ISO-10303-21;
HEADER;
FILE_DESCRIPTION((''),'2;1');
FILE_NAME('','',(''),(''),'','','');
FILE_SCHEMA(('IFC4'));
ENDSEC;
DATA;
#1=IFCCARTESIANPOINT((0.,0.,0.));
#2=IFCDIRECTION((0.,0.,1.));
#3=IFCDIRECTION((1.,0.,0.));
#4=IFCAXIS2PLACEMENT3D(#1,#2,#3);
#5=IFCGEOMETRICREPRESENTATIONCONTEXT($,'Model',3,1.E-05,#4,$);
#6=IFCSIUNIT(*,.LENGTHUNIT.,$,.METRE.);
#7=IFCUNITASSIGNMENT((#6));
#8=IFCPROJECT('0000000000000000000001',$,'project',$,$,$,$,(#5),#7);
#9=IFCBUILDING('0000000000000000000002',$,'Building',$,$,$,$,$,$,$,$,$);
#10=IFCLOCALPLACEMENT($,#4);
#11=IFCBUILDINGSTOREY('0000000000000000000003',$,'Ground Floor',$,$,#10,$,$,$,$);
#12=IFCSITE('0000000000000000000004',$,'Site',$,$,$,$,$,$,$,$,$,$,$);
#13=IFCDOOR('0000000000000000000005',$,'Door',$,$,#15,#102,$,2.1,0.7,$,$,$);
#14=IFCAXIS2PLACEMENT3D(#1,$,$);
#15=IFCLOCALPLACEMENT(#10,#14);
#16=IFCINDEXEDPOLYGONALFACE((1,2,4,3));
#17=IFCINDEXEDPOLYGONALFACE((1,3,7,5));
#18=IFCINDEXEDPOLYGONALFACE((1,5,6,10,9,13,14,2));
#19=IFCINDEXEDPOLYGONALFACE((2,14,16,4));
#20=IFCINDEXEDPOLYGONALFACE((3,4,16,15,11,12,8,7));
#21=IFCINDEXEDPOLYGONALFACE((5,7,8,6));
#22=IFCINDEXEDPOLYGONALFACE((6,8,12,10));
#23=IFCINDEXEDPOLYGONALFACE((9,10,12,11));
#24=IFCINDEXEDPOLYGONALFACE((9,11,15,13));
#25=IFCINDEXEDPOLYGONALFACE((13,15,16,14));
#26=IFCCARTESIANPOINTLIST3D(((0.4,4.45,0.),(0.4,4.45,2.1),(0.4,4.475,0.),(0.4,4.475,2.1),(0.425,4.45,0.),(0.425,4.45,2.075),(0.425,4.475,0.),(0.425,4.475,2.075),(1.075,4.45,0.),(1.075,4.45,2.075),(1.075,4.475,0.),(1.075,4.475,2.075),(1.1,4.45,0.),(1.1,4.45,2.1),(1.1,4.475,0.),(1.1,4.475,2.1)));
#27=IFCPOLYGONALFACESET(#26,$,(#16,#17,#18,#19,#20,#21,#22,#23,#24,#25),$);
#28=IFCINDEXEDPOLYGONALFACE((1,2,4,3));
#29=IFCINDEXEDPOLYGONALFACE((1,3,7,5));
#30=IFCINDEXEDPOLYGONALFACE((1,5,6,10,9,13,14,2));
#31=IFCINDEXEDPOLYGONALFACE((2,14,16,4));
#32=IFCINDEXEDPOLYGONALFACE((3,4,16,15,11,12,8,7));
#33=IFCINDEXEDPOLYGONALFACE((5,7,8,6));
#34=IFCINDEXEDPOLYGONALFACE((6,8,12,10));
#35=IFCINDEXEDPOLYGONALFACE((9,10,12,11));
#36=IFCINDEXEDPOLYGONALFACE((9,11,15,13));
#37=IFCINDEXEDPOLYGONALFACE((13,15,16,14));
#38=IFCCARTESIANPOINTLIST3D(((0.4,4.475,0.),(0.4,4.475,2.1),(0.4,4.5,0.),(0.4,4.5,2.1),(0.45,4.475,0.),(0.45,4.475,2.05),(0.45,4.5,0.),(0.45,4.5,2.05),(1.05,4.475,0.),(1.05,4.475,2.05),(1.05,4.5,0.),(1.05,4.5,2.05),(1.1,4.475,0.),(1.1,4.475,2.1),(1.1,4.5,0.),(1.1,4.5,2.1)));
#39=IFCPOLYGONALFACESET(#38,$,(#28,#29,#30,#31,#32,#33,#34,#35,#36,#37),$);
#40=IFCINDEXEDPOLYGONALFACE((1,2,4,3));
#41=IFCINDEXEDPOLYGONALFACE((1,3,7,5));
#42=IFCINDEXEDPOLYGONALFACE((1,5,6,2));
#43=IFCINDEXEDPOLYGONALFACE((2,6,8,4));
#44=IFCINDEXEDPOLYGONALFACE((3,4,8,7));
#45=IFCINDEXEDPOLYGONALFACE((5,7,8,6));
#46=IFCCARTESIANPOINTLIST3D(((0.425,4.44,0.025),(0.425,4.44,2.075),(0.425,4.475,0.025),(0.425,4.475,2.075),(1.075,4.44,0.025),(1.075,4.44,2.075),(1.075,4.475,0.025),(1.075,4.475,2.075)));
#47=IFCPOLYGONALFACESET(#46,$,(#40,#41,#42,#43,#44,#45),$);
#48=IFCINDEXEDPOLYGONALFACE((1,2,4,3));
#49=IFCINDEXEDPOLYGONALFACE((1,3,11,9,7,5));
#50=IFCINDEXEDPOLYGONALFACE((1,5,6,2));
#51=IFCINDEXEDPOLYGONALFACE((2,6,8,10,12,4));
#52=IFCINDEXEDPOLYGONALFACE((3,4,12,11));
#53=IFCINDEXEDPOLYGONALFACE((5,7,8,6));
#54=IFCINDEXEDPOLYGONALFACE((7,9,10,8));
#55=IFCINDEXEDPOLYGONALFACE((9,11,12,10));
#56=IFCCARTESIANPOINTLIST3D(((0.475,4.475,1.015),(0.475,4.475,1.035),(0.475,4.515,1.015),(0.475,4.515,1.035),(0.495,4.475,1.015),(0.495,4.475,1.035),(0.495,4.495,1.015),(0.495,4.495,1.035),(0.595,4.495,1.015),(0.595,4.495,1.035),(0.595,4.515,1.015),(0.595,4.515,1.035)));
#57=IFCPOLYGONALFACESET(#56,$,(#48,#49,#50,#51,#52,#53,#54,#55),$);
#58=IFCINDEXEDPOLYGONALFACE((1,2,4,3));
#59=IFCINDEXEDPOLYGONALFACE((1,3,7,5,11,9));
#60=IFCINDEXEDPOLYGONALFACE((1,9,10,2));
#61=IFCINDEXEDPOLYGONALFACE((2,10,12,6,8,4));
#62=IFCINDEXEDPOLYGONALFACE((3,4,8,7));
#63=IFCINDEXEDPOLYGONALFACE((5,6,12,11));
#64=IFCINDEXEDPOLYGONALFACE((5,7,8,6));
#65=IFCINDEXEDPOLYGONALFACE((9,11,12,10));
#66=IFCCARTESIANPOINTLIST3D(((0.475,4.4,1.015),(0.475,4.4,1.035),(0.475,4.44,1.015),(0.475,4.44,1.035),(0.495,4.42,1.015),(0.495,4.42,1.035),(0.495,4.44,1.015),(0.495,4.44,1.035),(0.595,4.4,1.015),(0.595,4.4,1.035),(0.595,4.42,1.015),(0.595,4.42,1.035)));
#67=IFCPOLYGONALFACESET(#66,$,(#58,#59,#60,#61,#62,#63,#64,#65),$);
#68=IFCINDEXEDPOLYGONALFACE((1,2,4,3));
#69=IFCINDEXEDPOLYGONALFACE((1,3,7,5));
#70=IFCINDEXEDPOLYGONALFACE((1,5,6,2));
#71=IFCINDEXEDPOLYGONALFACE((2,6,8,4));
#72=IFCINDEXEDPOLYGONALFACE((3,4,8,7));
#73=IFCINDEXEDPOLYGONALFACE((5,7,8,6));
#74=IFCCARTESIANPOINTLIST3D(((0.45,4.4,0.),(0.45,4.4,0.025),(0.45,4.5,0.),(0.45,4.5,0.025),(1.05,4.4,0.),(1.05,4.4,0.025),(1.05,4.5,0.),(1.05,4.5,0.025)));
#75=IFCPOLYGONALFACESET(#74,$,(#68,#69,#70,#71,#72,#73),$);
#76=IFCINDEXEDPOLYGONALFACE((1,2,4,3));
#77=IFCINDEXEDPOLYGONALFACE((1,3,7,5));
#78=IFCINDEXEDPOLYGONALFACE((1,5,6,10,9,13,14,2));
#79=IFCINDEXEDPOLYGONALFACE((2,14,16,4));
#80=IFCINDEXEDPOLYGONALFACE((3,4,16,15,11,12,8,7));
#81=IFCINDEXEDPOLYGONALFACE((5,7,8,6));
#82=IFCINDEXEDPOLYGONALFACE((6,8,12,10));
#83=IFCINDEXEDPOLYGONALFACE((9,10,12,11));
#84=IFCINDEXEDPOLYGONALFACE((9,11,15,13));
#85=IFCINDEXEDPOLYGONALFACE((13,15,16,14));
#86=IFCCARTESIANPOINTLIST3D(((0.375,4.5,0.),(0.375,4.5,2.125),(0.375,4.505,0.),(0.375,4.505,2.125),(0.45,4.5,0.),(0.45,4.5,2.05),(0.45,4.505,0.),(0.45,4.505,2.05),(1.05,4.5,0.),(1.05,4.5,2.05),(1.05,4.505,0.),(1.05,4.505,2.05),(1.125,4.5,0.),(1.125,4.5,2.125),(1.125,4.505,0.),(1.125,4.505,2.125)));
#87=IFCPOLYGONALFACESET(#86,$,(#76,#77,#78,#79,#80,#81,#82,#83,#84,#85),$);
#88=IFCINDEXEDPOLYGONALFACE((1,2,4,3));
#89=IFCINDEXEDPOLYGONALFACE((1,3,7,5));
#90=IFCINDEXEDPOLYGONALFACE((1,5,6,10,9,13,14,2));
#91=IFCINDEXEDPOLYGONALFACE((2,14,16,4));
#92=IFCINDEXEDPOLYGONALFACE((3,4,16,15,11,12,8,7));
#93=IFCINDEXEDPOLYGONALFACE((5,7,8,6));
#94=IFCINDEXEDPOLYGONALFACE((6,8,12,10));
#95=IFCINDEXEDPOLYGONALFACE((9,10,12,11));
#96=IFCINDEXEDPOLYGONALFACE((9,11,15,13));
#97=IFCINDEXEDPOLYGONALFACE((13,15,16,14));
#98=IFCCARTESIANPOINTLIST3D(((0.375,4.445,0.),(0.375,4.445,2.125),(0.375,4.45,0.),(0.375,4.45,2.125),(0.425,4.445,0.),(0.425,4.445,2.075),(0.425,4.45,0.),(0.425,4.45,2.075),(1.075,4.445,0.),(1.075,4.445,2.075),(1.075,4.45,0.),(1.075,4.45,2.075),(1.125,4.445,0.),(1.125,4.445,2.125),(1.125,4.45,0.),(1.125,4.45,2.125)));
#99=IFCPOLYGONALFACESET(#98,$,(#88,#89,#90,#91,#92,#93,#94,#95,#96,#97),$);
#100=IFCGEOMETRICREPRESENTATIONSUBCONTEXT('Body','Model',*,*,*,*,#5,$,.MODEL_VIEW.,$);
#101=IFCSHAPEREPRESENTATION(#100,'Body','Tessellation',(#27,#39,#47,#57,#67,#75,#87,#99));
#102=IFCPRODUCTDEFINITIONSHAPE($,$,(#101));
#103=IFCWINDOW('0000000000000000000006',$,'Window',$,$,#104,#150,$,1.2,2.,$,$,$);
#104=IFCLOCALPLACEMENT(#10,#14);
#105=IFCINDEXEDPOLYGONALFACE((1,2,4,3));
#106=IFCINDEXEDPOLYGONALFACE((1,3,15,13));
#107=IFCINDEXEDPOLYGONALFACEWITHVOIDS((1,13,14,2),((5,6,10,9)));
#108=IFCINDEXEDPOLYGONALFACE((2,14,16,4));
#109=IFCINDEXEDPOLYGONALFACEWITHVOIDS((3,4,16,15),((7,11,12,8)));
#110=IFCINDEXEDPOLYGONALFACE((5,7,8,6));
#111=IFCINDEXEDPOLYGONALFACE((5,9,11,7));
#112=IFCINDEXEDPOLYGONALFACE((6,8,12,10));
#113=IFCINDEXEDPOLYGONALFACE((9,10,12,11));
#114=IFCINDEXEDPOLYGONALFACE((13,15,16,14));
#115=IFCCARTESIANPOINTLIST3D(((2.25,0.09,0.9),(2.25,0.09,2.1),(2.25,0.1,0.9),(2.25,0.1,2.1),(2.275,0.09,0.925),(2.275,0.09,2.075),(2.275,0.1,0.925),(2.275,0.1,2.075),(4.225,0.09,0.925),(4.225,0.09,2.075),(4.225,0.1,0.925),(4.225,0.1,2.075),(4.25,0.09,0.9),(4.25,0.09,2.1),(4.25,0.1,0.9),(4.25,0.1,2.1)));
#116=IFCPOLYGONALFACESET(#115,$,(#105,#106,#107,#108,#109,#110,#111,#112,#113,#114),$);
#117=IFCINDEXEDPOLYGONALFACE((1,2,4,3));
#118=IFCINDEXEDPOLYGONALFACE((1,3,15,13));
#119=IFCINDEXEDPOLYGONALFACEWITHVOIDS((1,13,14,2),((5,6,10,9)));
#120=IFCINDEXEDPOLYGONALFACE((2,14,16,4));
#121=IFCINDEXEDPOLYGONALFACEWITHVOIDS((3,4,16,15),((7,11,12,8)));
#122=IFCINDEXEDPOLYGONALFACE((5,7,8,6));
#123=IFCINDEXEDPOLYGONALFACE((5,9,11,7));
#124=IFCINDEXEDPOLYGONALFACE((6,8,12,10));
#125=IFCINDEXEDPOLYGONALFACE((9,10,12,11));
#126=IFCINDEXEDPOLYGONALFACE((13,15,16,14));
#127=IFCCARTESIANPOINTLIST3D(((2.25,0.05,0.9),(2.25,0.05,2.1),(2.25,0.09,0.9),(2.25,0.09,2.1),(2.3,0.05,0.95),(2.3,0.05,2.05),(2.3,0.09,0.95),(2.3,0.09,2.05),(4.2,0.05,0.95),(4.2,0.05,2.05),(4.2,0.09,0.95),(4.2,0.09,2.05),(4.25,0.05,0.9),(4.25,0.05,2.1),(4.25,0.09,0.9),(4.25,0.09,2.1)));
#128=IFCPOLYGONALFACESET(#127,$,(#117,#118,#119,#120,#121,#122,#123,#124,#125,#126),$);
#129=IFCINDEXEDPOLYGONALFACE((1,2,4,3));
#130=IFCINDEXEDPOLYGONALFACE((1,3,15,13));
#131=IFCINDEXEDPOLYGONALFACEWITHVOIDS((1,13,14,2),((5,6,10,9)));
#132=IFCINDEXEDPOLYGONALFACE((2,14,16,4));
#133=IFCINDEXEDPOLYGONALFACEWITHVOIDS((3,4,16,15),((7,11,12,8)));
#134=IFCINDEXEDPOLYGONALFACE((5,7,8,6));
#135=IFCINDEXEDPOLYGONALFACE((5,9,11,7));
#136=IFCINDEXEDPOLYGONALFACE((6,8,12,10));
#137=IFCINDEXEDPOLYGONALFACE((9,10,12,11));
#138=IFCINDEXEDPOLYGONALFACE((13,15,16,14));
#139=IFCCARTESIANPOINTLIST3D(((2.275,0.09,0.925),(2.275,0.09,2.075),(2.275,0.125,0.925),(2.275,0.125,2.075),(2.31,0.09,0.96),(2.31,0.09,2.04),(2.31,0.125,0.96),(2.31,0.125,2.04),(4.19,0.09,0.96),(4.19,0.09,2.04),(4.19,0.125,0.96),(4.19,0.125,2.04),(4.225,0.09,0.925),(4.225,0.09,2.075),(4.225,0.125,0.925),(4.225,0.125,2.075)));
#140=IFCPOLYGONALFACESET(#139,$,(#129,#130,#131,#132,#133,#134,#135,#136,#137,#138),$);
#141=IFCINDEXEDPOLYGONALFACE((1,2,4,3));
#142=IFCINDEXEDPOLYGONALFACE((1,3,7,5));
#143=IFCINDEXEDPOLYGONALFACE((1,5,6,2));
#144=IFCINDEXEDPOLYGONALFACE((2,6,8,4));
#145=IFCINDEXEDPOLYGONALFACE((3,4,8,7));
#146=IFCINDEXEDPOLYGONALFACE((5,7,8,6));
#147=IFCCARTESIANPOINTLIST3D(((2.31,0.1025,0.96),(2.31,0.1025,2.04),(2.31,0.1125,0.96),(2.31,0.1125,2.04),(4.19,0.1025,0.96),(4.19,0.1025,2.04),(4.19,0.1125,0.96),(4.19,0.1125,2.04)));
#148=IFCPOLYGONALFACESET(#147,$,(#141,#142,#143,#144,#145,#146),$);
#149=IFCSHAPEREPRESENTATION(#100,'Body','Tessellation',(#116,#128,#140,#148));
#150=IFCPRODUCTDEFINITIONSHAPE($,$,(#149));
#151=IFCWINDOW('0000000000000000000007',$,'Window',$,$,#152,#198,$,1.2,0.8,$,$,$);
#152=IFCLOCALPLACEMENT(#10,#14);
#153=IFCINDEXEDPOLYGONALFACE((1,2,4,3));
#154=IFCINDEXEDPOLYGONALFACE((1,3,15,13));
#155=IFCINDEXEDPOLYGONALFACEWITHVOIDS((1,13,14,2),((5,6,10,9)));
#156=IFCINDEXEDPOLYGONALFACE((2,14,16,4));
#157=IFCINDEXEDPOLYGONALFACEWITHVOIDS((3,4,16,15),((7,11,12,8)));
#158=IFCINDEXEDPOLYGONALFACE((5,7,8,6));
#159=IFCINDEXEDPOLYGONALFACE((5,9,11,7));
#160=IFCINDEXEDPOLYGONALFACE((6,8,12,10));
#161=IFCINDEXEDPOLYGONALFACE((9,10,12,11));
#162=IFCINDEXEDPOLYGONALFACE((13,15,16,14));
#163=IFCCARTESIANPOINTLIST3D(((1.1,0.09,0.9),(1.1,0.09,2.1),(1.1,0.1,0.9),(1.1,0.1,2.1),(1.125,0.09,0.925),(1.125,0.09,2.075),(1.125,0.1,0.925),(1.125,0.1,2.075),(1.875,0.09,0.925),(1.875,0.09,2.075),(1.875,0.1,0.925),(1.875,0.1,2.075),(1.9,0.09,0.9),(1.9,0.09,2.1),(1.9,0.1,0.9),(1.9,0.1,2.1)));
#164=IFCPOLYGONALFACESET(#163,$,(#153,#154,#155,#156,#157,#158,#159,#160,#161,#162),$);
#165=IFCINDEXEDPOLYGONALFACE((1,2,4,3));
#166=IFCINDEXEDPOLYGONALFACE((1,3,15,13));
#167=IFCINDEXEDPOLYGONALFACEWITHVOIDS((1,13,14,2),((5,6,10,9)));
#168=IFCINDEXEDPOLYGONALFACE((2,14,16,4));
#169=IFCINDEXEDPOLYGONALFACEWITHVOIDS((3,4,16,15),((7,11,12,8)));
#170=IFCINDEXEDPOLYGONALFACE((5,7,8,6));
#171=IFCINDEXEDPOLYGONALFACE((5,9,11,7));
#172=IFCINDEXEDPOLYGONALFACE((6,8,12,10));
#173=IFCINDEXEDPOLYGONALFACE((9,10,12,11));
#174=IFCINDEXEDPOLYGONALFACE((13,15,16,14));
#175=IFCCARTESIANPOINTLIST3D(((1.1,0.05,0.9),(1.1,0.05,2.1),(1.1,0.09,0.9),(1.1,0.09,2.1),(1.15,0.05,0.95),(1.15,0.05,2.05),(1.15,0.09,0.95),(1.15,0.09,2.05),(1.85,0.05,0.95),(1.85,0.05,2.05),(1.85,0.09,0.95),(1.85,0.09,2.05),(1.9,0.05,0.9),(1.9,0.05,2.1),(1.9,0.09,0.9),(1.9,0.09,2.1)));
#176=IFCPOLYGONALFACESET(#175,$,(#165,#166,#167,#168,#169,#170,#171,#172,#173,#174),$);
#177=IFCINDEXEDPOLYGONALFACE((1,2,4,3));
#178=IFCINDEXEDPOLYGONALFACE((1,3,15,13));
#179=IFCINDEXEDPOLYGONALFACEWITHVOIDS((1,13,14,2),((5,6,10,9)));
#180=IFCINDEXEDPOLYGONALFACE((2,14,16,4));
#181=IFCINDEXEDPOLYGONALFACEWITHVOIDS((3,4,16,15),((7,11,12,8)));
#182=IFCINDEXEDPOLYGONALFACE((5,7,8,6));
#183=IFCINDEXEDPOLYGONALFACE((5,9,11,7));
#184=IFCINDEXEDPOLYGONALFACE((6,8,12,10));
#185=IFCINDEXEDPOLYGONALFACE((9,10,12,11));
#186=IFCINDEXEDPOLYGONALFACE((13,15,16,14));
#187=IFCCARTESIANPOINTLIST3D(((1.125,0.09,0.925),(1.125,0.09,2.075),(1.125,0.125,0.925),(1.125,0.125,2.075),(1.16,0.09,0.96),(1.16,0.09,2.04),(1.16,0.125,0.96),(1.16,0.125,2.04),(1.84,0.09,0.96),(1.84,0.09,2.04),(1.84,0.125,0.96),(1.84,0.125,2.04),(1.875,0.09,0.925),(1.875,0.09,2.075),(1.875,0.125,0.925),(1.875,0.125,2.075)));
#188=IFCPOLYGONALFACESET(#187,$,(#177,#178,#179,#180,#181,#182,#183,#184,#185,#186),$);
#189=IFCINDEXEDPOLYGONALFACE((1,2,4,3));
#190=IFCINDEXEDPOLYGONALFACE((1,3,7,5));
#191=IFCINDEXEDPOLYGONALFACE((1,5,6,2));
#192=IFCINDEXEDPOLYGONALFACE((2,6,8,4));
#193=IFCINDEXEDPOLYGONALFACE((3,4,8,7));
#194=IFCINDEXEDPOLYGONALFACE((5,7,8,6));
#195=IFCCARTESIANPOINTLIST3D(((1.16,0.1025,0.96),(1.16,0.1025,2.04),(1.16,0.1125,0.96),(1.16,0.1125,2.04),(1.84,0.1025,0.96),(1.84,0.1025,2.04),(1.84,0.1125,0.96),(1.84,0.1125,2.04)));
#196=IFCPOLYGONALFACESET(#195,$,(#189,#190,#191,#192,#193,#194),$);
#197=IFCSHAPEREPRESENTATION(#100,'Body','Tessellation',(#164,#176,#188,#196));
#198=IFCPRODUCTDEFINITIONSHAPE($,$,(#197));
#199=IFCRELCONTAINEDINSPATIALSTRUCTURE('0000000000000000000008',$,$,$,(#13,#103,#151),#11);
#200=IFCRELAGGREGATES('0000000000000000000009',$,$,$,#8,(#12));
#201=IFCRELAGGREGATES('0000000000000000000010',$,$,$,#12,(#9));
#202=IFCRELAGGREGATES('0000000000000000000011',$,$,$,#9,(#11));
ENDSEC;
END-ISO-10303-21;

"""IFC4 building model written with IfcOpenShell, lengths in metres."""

from ifc_helpers import new_model, si_unit, frame, origin_with_axes, place, context, subcontext, project, spatial, line, indexed_curve, outline, extrude, element, save


model = new_model("IFC4")

# Units and contexts
model_context = context("Model", 3, precision=1e-05, world=origin_with_axes())
body_context = subcontext(model_context, "Body", "Model", "MODEL_VIEW")
ifc_project = project(units=[si_unit("LENGTHUNIT", "METRE")], contexts=[model_context])

# Site, building, storey
site = spatial("IfcSite", under=ifc_project, Name="Site")
building = spatial("IfcBuilding", under=site, Name="Building")
storey_placement = place(None, origin_with_axes())
storey = spatial("IfcBuildingStorey", under=building, at=storey_placement, Name="Ground Floor")

# Door
door_1_placement = place(storey_placement, frame((1.1, 4.5, 0.0), z_axis=(0.0, 0.0, 1.0), x_axis=(-1.0, 0.0, 0.0)))
element("IfcDoor", 1, at=door_1_placement, inside=storey, Name="Door", OverallHeight=2.1, OverallWidth=0.7, context=body_context, shape_type="SweptSolid", body=[
    extrude(outline(indexed_curve([(0.0, 0.0), (0.0, 2.1), (0.7, 2.1), (0.7, 0.0), (0.675, 0.0), (0.675, 2.075), (0.025, 2.075), (0.025, 0.0)], segments=[line(1, 2, 3, 4, 5, 6, 7, 8, 1)])), frame((0.0, 0.025, 0.0), z_axis=(0.0, -1.0, 0.0), x_axis=(1.0, 0.0, 0.0)), (0.0, 0.0, -1.0), 0.025),
    extrude(outline(indexed_curve([(0.0, 0.0), (0.0, 2.1), (0.7, 2.1), (0.7, 0.0), (0.65, 0.0), (0.65, 2.05), (0.05, 2.05), (0.05, 0.0)], segments=[line(1, 2, 3, 4, 5, 6, 7, 8, 1)])), frame((0.0, 0.0, 0.0), z_axis=(0.0, -1.0, 0.0), x_axis=(1.0, 0.0, 0.0)), (0.0, 0.0, -1.0), 0.025),
    extrude(outline(indexed_curve([(0.0, 0.0), (0.65, 0.0), (0.65, 0.035), (0.0, 0.035)], segments=[line(1, 2, 3, 4, 1)])), frame((0.025, 0.025, 0.025), z_axis=(0.0, 0.0, 1.0), x_axis=(1.0, 0.0, 0.0)), (0.0, 0.0, 1.0), 2.05),
    extrude(outline(indexed_curve([(0.0, 0.0), (0.0, -0.04), (-0.12, -0.04), (-0.12, -0.02), (-0.02, -0.02), (-0.02, 0.0)], segments=[line(1, 2, 3, 4, 5, 6, 1)])), frame((0.625, 0.025, 1.015), z_axis=(0.0, 0.0, 1.0), x_axis=(1.0, 0.0, 0.0)), (0.0, 0.0, 1.0), 0.02),
    extrude(outline(indexed_curve([(0.0, 0.0), (0.0, 0.04), (-0.12, 0.04), (-0.12, 0.02), (-0.02, 0.02), (-0.02, 0.0)], segments=[line(1, 2, 3, 4, 5, 6, 1)])), frame((0.625, 0.06, 1.015), z_axis=(0.0, 0.0, 1.0), x_axis=(1.0, 0.0, 0.0)), (0.0, 0.0, 1.0), 0.02),
    extrude(outline(indexed_curve([(0.0, 0.0), (0.6, 0.0), (0.6, 0.1), (0.0, 0.1)], segments=[line(1, 2, 3, 4, 1)])), frame((0.05, 0.0, 0.0), z_axis=(0.0, 0.0, 1.0), x_axis=(1.0, 0.0, 0.0)), (0.0, 0.0, 1.0), 0.025),
    extrude(outline(indexed_curve([(0.0, 0.0), (0.0, 2.125), (0.75, 2.125), (0.75, 0.0), (0.675, 0.0), (0.675, 2.05), (0.075, 2.05), (0.075, 0.0)], segments=[line(1, 2, 3, 4, 5, 6, 7, 8, 1)])), frame((-0.025, -0.005, 0.0), z_axis=(0.0, -1.0, 0.0), x_axis=(1.0, 0.0, 0.0)), (0.0, 0.0, -1.0), 0.005),
    extrude(outline(indexed_curve([(0.0, 0.0), (0.0, 2.125), (0.75, 2.125), (0.75, 0.0), (0.7, 0.0), (0.7, 2.075), (0.05, 2.075), (0.05, 0.0)], segments=[line(1, 2, 3, 4, 5, 6, 7, 8, 1)])), frame((-0.025, 0.05, 0.0), z_axis=(0.0, -1.0, 0.0), x_axis=(1.0, 0.0, 0.0)), (0.0, 0.0, -1.0), 0.005),
])

# Windows
window_1_placement = place(storey_placement, frame((2.25, 0.0, 0.9), z_axis=(0.0, 0.0, 1.0), x_axis=(1.0, 0.0, 0.0)))
element("IfcWindow", 2, at=window_1_placement, inside=storey, Name="Window", OverallHeight=1.2, OverallWidth=2.0, context=body_context, shape_type="SweptSolid", body=[
    extrude(outline(indexed_curve([(0.0, 0.0), (2.0, 0.0), (2.0, 1.2), (0.0, 1.2)], segments=[line(1, 2, 3, 4, 1)]), holes=[indexed_curve([(0.025, 0.025), (1.975, 0.025), (1.975, 1.175), (0.025, 1.175)], segments=[line(1, 2, 3, 4, 1)])]), frame((0.0, 0.09, 0.0), z_axis=(0.0, -1.0, 0.0), x_axis=(1.0, 0.0, 0.0)), (0.0, 0.0, -1.0), 0.01),
    extrude(outline(indexed_curve([(0.0, 0.0), (2.0, 0.0), (2.0, 1.2), (0.0, 1.2)], segments=[line(1, 2, 3, 4, 1)]), holes=[indexed_curve([(0.05, 0.05), (1.95, 0.05), (1.95, 1.15), (0.05, 1.15)], segments=[line(1, 2, 3, 4, 1)])]), frame((0.0, 0.05, 0.0), z_axis=(0.0, -1.0, 0.0), x_axis=(1.0, 0.0, 0.0)), (0.0, 0.0, -1.0), 0.04),
    extrude(outline(indexed_curve([(0.0, 0.0), (1.95, 0.0), (1.95, 1.15), (0.0, 1.15)], segments=[line(1, 2, 3, 4, 1)]), holes=[indexed_curve([(0.035, 0.035), (1.915, 0.035), (1.915, 1.115), (0.035, 1.115)], segments=[line(1, 2, 3, 4, 1)])]), frame((0.025, 0.09, 0.025), z_axis=(0.0, -1.0, 0.0), x_axis=(1.0, 0.0, 0.0)), (0.0, 0.0, -1.0), 0.035),
    extrude(outline(indexed_curve([(0.035, 0.035), (1.915, 0.035), (1.915, 1.115), (0.035, 1.115)], segments=[line(1, 2, 3, 4, 1)])), frame((0.025, 0.1025, 0.025), z_axis=(0.0, -1.0, 0.0), x_axis=(1.0, 0.0, 0.0)), (0.0, 0.0, -1.0), 0.01),
])
window_2_placement = place(storey_placement, frame((1.1, 0.0, 0.9), z_axis=(0.0, 0.0, 1.0), x_axis=(1.0, 0.0, 0.0)))
element("IfcWindow", 3, at=window_2_placement, inside=storey, Name="Window", OverallHeight=1.2, OverallWidth=0.8, context=body_context, shape_type="SweptSolid", body=[
    extrude(outline(indexed_curve([(0.0, 0.0), (0.8, 0.0), (0.8, 1.2), (0.0, 1.2)], segments=[line(1, 2, 3, 4, 1)]), holes=[indexed_curve([(0.025, 0.025), (0.775, 0.025), (0.775, 1.175), (0.025, 1.175)], segments=[line(1, 2, 3, 4, 1)])]), frame((0.0, 0.09, 0.0), z_axis=(0.0, -1.0, 0.0), x_axis=(1.0, 0.0, 0.0)), (0.0, 0.0, -1.0), 0.01),
    extrude(outline(indexed_curve([(0.0, 0.0), (0.8, 0.0), (0.8, 1.2), (0.0, 1.2)], segments=[line(1, 2, 3, 4, 1)]), holes=[indexed_curve([(0.05, 0.05), (0.75, 0.05), (0.75, 1.15), (0.05, 1.15)], segments=[line(1, 2, 3, 4, 1)])]), frame((0.0, 0.05, 0.0), z_axis=(0.0, -1.0, 0.0), x_axis=(1.0, 0.0, 0.0)), (0.0, 0.0, -1.0), 0.04),
    extrude(outline(indexed_curve([(0.0, 0.0), (0.75, 0.0), (0.75, 1.15), (0.0, 1.15)], segments=[line(1, 2, 3, 4, 1)]), holes=[indexed_curve([(0.035, 0.035), (0.715, 0.035), (0.715, 1.115), (0.035, 1.115)], segments=[line(1, 2, 3, 4, 1)])]), frame((0.025, 0.09, 0.025), z_axis=(0.0, -1.0, 0.0), x_axis=(1.0, 0.0, 0.0)), (0.0, 0.0, -1.0), 0.035),
    extrude(outline(indexed_curve([(0.035, 0.035), (0.715, 0.035), (0.715, 1.115), (0.035, 1.115)], segments=[line(1, 2, 3, 4, 1)])), frame((0.025, 0.1025, 0.025), z_axis=(0.0, -1.0, 0.0), x_axis=(1.0, 0.0, 0.0)), (0.0, 0.0, -1.0), 0.01),
])

save(model, "model.ifc")
